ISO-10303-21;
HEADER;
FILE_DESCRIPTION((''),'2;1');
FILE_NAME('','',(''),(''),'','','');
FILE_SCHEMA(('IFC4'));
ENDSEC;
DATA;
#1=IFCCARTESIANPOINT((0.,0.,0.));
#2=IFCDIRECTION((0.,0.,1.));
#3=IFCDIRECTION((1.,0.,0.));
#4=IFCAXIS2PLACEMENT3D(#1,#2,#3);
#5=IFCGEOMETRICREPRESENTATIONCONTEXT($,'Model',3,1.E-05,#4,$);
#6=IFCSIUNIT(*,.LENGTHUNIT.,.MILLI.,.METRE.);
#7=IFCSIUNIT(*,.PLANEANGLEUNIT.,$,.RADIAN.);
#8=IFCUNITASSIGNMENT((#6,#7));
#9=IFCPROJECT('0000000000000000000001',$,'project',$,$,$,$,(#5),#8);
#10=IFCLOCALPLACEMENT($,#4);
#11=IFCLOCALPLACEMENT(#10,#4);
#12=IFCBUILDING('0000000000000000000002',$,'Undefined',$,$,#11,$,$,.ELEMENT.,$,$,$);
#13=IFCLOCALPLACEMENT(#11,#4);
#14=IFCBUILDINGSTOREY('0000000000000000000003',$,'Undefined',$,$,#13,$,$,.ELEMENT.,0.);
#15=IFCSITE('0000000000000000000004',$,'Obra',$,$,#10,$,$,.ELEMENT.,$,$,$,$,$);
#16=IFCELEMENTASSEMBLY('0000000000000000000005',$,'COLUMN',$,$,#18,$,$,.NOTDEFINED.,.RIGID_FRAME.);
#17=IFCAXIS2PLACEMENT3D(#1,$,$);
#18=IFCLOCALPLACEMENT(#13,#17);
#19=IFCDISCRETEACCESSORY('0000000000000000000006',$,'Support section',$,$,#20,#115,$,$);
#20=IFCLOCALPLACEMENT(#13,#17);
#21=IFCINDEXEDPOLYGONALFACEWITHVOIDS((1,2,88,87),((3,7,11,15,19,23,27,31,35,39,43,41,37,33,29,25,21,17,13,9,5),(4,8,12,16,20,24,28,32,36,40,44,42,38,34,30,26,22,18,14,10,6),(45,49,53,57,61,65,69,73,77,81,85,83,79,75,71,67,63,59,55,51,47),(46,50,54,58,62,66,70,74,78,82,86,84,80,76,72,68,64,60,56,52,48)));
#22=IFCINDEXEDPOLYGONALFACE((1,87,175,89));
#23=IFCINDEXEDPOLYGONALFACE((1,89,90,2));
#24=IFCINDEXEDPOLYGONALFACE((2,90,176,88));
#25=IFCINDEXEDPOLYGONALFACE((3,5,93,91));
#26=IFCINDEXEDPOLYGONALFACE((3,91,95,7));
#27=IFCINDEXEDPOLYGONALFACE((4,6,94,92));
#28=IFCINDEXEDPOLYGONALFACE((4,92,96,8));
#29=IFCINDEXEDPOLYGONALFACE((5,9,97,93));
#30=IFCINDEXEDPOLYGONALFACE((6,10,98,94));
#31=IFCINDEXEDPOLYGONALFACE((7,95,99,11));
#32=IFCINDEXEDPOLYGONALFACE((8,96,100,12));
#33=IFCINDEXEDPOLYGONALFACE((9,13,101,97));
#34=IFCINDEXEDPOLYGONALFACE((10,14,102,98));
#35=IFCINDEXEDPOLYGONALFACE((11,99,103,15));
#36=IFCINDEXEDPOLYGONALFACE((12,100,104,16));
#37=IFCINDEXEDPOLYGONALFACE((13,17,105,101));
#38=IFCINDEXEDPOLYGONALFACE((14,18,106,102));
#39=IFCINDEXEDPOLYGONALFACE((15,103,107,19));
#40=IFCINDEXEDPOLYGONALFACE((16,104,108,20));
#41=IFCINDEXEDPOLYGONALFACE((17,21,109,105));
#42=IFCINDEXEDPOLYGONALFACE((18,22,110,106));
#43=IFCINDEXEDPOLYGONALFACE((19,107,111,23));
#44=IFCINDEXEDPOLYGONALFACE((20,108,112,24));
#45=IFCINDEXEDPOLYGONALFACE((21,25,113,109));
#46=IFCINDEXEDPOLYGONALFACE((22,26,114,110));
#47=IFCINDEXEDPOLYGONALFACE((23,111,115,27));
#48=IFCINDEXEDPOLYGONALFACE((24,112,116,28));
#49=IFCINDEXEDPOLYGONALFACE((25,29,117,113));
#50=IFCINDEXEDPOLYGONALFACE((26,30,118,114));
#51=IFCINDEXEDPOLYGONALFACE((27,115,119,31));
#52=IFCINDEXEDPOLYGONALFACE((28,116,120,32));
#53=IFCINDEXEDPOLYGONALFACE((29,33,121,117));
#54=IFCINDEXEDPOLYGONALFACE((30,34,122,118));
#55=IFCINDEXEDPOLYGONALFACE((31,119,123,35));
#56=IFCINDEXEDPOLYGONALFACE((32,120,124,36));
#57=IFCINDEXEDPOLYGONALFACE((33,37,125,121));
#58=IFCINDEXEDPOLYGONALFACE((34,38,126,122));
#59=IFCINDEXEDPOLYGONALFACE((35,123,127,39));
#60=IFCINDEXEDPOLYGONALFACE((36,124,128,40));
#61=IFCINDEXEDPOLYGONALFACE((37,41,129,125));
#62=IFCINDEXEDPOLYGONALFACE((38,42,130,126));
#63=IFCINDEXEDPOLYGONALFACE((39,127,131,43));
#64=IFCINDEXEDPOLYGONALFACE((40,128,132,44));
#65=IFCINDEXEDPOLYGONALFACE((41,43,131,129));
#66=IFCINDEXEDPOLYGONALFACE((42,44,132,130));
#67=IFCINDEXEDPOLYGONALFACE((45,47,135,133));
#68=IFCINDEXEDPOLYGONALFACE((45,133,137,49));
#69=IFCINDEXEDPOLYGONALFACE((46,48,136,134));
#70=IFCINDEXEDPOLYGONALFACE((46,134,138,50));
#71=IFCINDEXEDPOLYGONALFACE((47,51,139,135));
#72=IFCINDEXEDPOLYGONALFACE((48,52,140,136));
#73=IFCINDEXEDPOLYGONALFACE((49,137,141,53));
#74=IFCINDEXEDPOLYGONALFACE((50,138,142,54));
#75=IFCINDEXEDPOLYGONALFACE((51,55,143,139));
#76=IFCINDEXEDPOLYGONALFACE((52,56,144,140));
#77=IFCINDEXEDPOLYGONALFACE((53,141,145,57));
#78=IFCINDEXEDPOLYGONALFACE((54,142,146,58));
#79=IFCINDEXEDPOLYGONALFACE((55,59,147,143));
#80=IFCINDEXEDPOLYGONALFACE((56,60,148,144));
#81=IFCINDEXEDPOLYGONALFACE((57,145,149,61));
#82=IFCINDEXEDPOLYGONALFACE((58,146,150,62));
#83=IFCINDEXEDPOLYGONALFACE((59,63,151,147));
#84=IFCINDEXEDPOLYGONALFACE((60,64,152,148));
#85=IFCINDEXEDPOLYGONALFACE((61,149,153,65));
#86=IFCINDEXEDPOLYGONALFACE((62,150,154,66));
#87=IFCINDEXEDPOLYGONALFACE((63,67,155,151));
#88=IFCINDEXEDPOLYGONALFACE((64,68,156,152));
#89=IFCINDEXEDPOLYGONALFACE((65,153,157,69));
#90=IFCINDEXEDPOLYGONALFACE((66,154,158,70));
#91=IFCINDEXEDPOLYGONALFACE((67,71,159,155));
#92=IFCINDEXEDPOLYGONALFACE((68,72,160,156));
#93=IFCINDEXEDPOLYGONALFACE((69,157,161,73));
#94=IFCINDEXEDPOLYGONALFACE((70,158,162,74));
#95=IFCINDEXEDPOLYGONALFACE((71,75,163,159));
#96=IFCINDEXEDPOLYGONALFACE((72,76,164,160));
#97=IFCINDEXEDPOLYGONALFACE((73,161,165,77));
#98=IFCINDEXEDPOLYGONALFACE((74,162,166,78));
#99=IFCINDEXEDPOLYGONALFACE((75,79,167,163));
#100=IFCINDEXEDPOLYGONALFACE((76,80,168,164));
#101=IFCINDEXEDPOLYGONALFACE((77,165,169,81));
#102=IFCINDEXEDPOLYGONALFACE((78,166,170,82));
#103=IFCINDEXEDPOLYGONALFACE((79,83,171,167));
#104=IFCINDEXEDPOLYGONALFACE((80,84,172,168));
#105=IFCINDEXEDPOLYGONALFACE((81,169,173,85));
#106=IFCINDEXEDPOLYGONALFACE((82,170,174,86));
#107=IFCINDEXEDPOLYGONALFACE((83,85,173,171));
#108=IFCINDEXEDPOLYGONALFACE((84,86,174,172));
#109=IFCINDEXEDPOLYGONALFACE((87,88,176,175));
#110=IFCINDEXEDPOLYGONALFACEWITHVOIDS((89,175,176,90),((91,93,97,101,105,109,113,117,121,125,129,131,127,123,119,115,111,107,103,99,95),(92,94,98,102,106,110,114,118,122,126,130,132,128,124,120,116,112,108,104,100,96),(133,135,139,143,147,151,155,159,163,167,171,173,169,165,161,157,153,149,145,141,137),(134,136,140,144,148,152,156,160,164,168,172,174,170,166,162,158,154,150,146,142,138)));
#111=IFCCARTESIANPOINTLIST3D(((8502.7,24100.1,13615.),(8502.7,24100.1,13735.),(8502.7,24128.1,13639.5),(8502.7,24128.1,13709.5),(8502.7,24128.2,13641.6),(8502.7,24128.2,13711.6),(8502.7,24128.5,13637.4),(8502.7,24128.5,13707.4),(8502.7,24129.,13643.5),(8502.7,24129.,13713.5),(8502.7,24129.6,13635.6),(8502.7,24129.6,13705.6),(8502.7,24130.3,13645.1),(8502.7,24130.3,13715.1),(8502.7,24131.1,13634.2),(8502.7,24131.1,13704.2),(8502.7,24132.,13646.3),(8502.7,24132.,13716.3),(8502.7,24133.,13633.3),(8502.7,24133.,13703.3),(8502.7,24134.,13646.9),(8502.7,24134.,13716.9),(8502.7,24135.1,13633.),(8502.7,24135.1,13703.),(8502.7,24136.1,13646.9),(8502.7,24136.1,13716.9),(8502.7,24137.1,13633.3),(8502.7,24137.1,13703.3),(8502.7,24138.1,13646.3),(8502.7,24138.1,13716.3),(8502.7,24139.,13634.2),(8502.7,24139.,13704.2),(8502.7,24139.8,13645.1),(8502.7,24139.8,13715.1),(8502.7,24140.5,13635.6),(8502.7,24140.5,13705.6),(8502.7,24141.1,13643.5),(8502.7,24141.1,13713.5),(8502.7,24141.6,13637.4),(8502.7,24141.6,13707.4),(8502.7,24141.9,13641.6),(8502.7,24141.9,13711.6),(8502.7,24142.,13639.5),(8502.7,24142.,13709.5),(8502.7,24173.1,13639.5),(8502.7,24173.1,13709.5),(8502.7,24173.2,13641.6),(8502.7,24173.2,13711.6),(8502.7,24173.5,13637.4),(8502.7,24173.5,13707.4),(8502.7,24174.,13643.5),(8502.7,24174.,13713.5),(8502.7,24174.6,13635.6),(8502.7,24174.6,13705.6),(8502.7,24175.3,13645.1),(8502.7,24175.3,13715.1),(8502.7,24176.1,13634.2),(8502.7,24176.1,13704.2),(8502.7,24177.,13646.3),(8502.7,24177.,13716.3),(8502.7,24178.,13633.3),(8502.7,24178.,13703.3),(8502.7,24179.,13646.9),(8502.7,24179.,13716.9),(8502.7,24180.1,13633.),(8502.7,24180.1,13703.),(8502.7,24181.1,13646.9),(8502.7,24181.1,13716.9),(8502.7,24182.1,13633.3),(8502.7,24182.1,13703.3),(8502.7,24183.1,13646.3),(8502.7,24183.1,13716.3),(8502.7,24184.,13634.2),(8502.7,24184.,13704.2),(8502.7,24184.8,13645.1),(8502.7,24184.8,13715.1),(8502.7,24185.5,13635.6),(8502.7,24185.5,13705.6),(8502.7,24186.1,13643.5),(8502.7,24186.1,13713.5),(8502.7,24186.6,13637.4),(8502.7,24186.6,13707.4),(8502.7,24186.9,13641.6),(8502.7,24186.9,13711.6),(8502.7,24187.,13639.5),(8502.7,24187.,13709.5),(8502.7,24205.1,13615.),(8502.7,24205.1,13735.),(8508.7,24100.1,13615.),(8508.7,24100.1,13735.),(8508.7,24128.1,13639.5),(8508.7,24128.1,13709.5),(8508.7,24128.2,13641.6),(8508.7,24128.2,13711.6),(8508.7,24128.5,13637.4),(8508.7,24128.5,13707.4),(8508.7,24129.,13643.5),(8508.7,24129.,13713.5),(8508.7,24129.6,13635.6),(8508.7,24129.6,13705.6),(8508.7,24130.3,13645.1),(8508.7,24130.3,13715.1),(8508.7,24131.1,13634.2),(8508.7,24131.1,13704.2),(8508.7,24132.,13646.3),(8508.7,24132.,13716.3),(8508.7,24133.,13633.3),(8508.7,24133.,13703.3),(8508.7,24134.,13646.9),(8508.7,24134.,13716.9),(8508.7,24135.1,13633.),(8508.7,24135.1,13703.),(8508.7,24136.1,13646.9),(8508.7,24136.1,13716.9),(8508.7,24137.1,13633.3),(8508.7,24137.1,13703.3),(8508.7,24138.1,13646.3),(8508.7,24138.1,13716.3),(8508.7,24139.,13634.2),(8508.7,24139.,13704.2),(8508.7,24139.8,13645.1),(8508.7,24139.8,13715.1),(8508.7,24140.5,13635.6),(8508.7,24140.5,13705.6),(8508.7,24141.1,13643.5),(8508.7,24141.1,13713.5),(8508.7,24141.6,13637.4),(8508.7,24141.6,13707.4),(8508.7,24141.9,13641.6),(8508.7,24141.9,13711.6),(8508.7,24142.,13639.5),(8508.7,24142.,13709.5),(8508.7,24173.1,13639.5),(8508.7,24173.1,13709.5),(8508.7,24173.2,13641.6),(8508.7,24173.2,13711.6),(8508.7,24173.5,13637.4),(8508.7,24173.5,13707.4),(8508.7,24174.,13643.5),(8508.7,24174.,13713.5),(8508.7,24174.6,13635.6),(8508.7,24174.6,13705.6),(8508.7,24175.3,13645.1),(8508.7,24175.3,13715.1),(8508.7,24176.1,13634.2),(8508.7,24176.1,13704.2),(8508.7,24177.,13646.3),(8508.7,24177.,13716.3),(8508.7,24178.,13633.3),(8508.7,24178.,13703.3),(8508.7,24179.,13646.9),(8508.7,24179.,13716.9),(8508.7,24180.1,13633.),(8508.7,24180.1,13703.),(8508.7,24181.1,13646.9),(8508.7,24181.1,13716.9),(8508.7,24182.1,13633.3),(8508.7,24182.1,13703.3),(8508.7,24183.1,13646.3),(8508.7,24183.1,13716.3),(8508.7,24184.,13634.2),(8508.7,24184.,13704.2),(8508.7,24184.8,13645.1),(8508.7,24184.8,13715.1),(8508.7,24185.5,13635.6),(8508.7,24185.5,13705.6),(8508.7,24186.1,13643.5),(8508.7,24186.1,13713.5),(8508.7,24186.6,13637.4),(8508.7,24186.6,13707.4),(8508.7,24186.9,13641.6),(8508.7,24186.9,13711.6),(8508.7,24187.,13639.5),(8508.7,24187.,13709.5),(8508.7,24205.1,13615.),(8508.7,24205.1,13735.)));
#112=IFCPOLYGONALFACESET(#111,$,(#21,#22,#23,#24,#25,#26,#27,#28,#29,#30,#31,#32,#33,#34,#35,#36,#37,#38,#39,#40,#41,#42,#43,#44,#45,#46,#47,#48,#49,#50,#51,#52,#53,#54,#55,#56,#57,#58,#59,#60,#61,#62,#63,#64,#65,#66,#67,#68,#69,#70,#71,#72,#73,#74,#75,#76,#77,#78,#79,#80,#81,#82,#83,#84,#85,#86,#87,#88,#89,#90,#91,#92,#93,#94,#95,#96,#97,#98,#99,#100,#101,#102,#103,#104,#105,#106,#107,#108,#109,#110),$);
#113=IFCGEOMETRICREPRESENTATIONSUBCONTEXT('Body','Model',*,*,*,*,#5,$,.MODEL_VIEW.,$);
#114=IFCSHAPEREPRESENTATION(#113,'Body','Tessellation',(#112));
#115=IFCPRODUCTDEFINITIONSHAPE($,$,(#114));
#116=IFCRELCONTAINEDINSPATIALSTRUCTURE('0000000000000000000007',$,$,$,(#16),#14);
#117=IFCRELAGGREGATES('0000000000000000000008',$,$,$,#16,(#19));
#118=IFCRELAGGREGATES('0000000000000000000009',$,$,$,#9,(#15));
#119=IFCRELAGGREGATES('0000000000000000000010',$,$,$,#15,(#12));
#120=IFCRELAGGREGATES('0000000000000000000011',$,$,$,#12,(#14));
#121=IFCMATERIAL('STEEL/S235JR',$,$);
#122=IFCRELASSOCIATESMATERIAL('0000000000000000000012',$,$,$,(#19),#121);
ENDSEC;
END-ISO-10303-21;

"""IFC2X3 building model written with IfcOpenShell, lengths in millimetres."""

from ifc_helpers import new_model, si_unit, frame, origin_with_axes, origin_2d_with_axis, place, context, subcontext, project, spatial, rectangle, circle, extrude, source, transform, mapped, material, element, aggregate, save


model = new_model("IFC2X3")

# Units and contexts
model_context = context("Model", 3, precision=1e-05, world=origin_with_axes())
body_context = subcontext(model_context, "Body", "Model", "MODEL_VIEW")
ifc_project = project(units=[si_unit("LENGTHUNIT", "METRE", prefix="MILLI"), si_unit("PLANEANGLEUNIT", "RADIAN")], contexts=[model_context])

# Site, building, storey
site_placement = place(None, origin_with_axes())
site = spatial("IfcSite", under=ifc_project, at=site_placement, Name="Obra", CompositionType="ELEMENT")
building_placement = place(site_placement, origin_with_axes())
building = spatial("IfcBuilding", under=site, at=building_placement, Name="Undefined", CompositionType="ELEMENT")
storey_placement = place(building_placement, origin_with_axes())
storey = spatial("IfcBuildingStorey", under=building, at=storey_placement, Name="Undefined", CompositionType="ELEMENT", Elevation=0.0)

# Shared definitions
ifc_material_1 = material(Name="STEEL/S235JR")

# Element assembly
assembly_1_placement = place(storey_placement, origin_with_axes())
assembly_1 = element("IfcElementAssembly", 1, at=assembly_1_placement, inside=storey, Name="COLUMN", AssemblyPlace="NOTDEFINED", PredefinedType="RIGID_FRAME")

# Discrete accessory, opening
discrete_accessory_1_placement = place(assembly_1_placement, frame((8505.7, 24152.6, 13615.0), z_axis=(0.0, 0.0, 1.0), x_axis=(0.0, -1.0, 0.0)))
discrete_accessory_1 = element("IfcDiscreteAccessory", 2, at=discrete_accessory_1_placement, material=ifc_material_1, Name="Support section", context=body_context, shape_type="SweptSolid", body=[
    extrude(rectangle(XDim=6.0, YDim=105.0, at=origin_2d_with_axis()), frame((0.0, 0.0, 120.0), z_axis=(0.0, 0.0, -1.0), x_axis=(0.0, 1.0, 0.0)), (0.0, 0.0, 1.0), 120.0),
])
shared_shape_1 = source(origin_with_axes(), body_context, "Body", "SweptSolid", [
    extrude(circle(Radius=7.0, at=origin_2d_with_axis()), frame((0.0, -8.6, 0.0), z_axis=(0.0, 1.0, 0.0), x_axis=(1.0, 0.0, 0.0)), (0.0, 0.0, 1.0), 6.2),
])
opening_1_placement = place(assembly_1_placement, frame((8500.2, 24110.1, 13755.0), z_axis=(0.0, 1.0, 0.0), x_axis=(0.0, 0.0, -1.0)))
element("IfcOpeningElement", 3, at=opening_1_placement, cuts=discrete_accessory_1, ObjectType="Opening", context=body_context, shape_type="MappedRepresentation", body=[
    mapped(shared_shape_1, transform((45.0, 0.0, 25.0))),
    mapped(shared_shape_1, transform((45.0, 0.0, 70.0))),
    mapped(shared_shape_1, transform((115.0, 0.0, 25.0))),
    mapped(shared_shape_1, transform((115.0, 0.0, 70.0))),
])
aggregate(assembly_1, [discrete_accessory_1])

save(model, "model.ifc")
